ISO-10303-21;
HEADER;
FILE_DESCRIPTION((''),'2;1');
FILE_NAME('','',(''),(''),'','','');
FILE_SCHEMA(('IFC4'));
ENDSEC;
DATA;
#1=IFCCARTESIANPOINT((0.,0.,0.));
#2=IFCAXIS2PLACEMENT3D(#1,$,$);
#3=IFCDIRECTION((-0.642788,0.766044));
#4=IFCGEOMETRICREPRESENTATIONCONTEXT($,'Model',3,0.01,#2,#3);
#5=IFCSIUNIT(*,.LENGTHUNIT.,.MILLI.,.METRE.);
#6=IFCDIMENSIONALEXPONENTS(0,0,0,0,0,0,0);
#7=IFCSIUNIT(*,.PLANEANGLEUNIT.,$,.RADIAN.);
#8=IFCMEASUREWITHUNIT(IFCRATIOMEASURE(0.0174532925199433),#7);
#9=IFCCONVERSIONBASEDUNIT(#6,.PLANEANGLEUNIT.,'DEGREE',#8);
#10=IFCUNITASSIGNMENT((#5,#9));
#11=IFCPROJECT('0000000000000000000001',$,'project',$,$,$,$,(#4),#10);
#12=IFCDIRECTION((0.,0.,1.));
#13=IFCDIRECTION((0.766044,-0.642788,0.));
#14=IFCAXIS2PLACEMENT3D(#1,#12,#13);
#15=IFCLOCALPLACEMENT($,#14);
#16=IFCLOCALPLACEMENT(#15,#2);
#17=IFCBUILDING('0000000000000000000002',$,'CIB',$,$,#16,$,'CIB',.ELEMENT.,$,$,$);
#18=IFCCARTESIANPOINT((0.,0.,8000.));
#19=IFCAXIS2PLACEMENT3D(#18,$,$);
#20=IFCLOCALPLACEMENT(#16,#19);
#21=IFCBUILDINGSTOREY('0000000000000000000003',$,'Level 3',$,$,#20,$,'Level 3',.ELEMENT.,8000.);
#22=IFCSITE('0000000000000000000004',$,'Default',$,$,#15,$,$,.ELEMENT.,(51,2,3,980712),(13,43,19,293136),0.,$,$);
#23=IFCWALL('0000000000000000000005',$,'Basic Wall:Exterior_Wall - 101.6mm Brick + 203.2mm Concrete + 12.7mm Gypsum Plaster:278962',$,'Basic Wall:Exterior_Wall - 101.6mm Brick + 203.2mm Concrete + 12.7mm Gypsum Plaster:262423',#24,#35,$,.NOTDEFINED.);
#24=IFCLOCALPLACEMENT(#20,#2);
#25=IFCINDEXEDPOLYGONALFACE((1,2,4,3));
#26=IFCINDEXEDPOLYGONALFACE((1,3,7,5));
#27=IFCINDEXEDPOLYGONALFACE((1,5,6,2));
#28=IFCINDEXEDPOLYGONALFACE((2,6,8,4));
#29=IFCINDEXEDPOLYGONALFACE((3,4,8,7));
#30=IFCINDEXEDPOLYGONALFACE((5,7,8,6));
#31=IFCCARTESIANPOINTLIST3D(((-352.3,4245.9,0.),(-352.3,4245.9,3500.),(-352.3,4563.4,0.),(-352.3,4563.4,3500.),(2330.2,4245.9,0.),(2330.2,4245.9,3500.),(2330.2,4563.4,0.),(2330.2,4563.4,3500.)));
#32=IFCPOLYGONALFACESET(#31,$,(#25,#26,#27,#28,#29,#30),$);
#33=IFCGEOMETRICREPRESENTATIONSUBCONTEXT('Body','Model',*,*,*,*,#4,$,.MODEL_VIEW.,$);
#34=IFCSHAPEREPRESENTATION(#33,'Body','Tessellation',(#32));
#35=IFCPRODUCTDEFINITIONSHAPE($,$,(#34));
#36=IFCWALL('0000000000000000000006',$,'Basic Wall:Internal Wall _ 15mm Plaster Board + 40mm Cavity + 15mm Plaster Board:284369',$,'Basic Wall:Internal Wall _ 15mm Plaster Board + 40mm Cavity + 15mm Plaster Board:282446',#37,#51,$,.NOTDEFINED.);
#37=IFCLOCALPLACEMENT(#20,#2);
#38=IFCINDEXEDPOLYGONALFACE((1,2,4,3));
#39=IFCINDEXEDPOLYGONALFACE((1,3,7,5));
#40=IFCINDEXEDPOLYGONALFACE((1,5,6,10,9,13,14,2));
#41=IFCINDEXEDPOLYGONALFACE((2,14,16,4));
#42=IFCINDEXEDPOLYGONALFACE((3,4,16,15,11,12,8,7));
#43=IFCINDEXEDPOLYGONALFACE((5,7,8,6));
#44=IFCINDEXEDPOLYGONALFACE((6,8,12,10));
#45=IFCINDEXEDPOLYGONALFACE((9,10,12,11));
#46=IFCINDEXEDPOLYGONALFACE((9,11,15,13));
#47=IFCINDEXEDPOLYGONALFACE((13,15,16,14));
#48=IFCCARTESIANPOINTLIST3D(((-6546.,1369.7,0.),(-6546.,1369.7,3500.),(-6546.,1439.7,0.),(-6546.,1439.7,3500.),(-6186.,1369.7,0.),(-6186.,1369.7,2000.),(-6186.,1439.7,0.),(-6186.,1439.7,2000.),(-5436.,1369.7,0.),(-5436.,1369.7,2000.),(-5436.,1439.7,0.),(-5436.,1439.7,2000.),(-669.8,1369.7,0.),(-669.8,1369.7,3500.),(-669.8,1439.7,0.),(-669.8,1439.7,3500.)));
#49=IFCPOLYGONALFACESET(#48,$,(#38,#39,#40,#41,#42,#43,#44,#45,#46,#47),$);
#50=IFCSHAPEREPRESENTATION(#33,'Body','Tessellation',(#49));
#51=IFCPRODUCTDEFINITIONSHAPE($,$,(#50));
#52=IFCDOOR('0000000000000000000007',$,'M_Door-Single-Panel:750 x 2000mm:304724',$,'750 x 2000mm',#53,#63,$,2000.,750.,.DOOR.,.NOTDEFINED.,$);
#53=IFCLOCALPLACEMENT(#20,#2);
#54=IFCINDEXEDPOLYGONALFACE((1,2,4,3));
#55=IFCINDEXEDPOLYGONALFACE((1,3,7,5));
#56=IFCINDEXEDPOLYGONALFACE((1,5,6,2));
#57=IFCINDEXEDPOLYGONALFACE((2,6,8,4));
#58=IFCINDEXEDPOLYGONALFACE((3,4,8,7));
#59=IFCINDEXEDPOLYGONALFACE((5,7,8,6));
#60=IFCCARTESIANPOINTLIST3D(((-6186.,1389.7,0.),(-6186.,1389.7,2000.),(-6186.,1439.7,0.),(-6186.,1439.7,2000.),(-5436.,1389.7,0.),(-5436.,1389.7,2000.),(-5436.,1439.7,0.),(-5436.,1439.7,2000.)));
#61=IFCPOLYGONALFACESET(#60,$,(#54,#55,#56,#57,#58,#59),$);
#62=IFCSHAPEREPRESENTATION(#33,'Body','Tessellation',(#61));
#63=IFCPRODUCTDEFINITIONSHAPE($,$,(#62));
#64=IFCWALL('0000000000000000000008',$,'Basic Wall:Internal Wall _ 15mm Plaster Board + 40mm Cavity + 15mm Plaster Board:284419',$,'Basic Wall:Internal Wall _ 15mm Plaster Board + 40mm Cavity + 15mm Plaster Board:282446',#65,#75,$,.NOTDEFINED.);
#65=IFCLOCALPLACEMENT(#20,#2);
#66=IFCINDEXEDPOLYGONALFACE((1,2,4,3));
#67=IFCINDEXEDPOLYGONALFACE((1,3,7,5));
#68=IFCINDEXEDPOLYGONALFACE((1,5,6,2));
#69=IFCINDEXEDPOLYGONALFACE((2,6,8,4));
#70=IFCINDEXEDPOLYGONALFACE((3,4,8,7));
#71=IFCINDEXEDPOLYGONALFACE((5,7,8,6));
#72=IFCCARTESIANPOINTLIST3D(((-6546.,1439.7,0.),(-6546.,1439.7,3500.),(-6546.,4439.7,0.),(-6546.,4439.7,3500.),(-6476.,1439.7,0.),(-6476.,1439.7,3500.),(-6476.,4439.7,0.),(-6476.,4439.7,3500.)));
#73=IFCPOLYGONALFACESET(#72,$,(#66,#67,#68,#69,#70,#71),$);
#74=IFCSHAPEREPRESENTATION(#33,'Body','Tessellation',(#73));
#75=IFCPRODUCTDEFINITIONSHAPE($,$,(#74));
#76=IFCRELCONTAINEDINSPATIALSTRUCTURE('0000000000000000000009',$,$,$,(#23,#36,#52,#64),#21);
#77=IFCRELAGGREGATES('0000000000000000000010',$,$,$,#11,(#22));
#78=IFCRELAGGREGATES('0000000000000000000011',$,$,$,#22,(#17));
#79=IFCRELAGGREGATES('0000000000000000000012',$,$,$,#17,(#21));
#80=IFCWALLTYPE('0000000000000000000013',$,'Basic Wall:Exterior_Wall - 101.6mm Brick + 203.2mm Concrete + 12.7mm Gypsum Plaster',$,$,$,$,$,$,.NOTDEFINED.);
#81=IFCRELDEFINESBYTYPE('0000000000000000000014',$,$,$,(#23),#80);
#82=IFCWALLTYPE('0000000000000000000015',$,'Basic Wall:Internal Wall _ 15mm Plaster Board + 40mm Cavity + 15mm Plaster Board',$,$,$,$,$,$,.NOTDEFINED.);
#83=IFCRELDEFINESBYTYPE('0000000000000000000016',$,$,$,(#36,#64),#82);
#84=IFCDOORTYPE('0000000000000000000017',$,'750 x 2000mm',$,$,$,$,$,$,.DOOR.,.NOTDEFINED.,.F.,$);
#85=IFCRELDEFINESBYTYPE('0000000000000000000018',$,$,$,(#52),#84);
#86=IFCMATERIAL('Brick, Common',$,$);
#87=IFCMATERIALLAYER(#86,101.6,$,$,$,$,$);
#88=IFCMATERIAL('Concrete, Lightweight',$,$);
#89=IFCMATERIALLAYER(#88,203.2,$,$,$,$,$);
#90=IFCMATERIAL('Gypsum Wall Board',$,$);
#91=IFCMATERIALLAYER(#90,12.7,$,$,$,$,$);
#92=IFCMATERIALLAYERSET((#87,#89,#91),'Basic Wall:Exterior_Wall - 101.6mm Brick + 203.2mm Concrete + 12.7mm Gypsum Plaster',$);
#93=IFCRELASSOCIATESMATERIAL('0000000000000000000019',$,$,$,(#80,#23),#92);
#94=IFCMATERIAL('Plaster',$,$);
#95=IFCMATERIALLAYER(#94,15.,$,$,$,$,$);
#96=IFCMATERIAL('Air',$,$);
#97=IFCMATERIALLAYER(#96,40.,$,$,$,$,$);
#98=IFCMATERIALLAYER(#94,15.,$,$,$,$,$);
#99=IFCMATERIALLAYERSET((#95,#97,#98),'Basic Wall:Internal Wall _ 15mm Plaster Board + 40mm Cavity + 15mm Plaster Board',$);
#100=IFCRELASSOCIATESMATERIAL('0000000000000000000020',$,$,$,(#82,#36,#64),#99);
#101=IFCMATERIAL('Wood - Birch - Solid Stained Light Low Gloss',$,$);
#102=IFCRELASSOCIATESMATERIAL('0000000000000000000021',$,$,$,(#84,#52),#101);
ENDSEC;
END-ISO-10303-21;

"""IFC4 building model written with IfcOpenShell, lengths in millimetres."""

from ifc_helpers import new_model, entity, si_unit, converted_unit, direction, frame, frame_2d, origin, origin_2d_with_axis, place, context, subcontext, project, spatial, rectangle, extrude, source, transform, mapped, material, layer, layer_set, layer_usage, type_object, type_shapes, element, fill, save


model = new_model("IFC4")

# Units and contexts
model_context = context("Model", 3, precision=0.01, world=origin(), true_north=direction((-0.642788, 0.766044)))
body_context = subcontext(model_context, "Body", "Model", "MODEL_VIEW")
ifc_project = project(units=[si_unit("LENGTHUNIT", "METRE", prefix="MILLI"), converted_unit("PLANEANGLEUNIT", "DEGREE", entity("IfcRatioMeasure", 0.0174532925199433), si_unit("PLANEANGLEUNIT", "RADIAN"), dimensions=[0, 0, 0, 0, 0, 0, 0])], contexts=[model_context])

# Site, building, storey
site_placement = place(None, frame((0.0, 0.0, 0.0), z_axis=(0.0, 0.0, 1.0), x_axis=(0.766044, -0.642788, 0.0)))
site = spatial("IfcSite", under=ifc_project, at=site_placement, Name="Default", CompositionType="ELEMENT", RefLatitude=(51, 2, 3, 980712), RefLongitude=(13, 43, 19, 293136), RefElevation=0.0)
building_placement = place(site_placement, origin())
building = spatial("IfcBuilding", under=site, at=building_placement, Name="CIB", LongName="CIB", CompositionType="ELEMENT")
storey_placement = place(building_placement, frame((0.0, 0.0, 8000.0)))
storey = spatial("IfcBuildingStorey", under=building, at=storey_placement, Name="Level 3", LongName="Level 3", CompositionType="ELEMENT", Elevation=8000.0)

# Shared definitions
ifc_material_1 = material(Name="Plaster")

# Shared definitions
ifc_material_2 = material(Name="Brick, Common")
ifc_layer_1 = layer(ifc_material_2, 101.6)
ifc_material_3 = material(Name="Concrete, Lightweight")
ifc_layer_2 = layer(ifc_material_3, 203.2)
ifc_material_4 = material(Name="Gypsum Wall Board")
ifc_layer_3 = layer(ifc_material_4, 12.7)
ifc_layer_set_1 = layer_set([ifc_layer_1, ifc_layer_2, ifc_layer_3], Name="Basic Wall:Exterior_Wall - 101.6mm Brick + 203.2mm Concrete + 12.7mm Gypsum Plaster")
wall_type_1 = type_object("IfcWallType", Name="Basic Wall:Exterior_Wall - 101.6mm Brick + 203.2mm Concrete + 12.7mm Gypsum Plaster", PredefinedType="NOTDEFINED", material=ifc_layer_set_1)

# Wall
ifc_layer_usage_1 = layer_usage(ifc_layer_set_1, "AXIS2", "NEGATIVE", 158.8)
wall_1_placement = place(storey_placement, frame((-352.3, 4404.7, 0.0)))
element("IfcWall", 1, at=wall_1_placement, inside=storey, type_object=wall_type_1, material=ifc_layer_usage_1, Name="Basic Wall:Exterior_Wall - 101.6mm Brick + 203.2mm Concrete + 12.7mm Gypsum Plaster:278962", ObjectType="Basic Wall:Exterior_Wall - 101.6mm Brick + 203.2mm Concrete + 12.7mm Gypsum Plaster:262423", PredefinedType="NOTDEFINED", context=body_context, shape_type="SweptSolid", body=[
    extrude(rectangle(XDim=2682.5, YDim=317.5, at=frame_2d((1341.2, 0.0), x_axis=(-1.0, 0.0))), origin(), (0.0, 0.0, 1.0), 3500.0),
])

# Wall, opening, door
ifc_layer_4 = layer(ifc_material_1, 15.0)
ifc_material_5 = material(Name="Air")
ifc_layer_5 = layer(ifc_material_5, 40.0)
ifc_layer_6 = layer(ifc_material_1, 15.0)
ifc_layer_set_2 = layer_set([ifc_layer_4, ifc_layer_5, ifc_layer_6], Name="Basic Wall:Internal Wall _ 15mm Plaster Board + 40mm Cavity + 15mm Plaster Board")
ifc_layer_usage_2 = layer_usage(ifc_layer_set_2, "AXIS2", "NEGATIVE", 35.0)
wall_type_2 = type_object("IfcWallType", Name="Basic Wall:Internal Wall _ 15mm Plaster Board + 40mm Cavity + 15mm Plaster Board", PredefinedType="NOTDEFINED", material=ifc_layer_set_2)
wall_2_placement = place(storey_placement, frame((-669.8, 1404.7, 0.0), z_axis=(0.0, 0.0, 1.0), x_axis=(-1.0, 0.0, 0.0)))
wall_2 = element("IfcWall", 2, at=wall_2_placement, inside=storey, type_object=wall_type_2, material=ifc_layer_usage_2, Name="Basic Wall:Internal Wall _ 15mm Plaster Board + 40mm Cavity + 15mm Plaster Board:284369", ObjectType="Basic Wall:Internal Wall _ 15mm Plaster Board + 40mm Cavity + 15mm Plaster Board:282446", PredefinedType="NOTDEFINED", context=body_context, shape_type="SweptSolid", body=[
    extrude(rectangle(XDim=5876.2, YDim=70.0, at=frame_2d((2938.1, 0.0), x_axis=(-1.0, 0.0))), origin(), (0.0, 0.0, 1.0), 3500.0),
])
opening_1_placement = place(wall_2_placement, frame((5516.2, 35.0, 0.0)))
opening_1 = element("IfcOpeningElement", 3, at=opening_1_placement, cuts=wall_2, ObjectType="Opening", PredefinedType="OPENING", context=body_context, shape_type="SweptSolid", body=[
    extrude(rectangle(XDim=750.0, YDim=2000.0, at=frame_2d((1000.0, 375.0), x_axis=(0.0, -1.0))), frame((0.0, 0.0, 0.0), z_axis=(0.0, -1.0, 0.0), x_axis=(0.0, 0.0, 1.0)), (0.0, 0.0, 1.0), 70.0),
])
ifc_material_6 = material(Name="Wood - Birch - Solid Stained Light Low Gloss")
door_type = type_object("IfcDoorType", Name="750 x 2000mm", OperationType="NOTDEFINED", ParameterTakesPrecedence=False, PredefinedType="DOOR", material=ifc_material_6)
shared_shape_1 = source(origin(), body_context, "Body", "SweptSolid", [
    extrude(rectangle(XDim=750.0, YDim=50.0, at=origin_2d_with_axis()), frame((375.0, 45.0, 0.0)), (0.0, 0.0, 1.0), 2000.0),
])
type_shapes(door_type, [shared_shape_1])
door_placement = place(opening_1_placement, frame((0.0, 0.0, 0.0), z_axis=(0.0, 0.0, 1.0), x_axis=(-1.0, 0.0, 0.0)))
door = element("IfcDoor", 4, at=door_placement, inside=storey, type_object=door_type, material=ifc_material_6, Name="M_Door-Single-Panel:750 x 2000mm:304724", ObjectType="750 x 2000mm", OperationType="NOTDEFINED", OverallHeight=2000.0, OverallWidth=750.0, PredefinedType="DOOR", context=body_context, shape_type="MappedRepresentation", body=[
    mapped(shared_shape_1, transform((0.0, 0.0, 0.0), scale=1.0)),
])
fill(opening_1, door)

# Wall
ifc_layer_usage_3 = layer_usage(ifc_layer_set_2, "AXIS2", "NEGATIVE", 35.0)
wall_3_placement = place(storey_placement, frame((-6511.0, 1439.7, 0.0), z_axis=(0.0, 0.0, 1.0), x_axis=(0.0, 1.0, 0.0)))
element("IfcWall", 5, at=wall_3_placement, inside=storey, type_object=wall_type_2, material=ifc_layer_usage_3, Name="Basic Wall:Internal Wall _ 15mm Plaster Board + 40mm Cavity + 15mm Plaster Board:284419", ObjectType="Basic Wall:Internal Wall _ 15mm Plaster Board + 40mm Cavity + 15mm Plaster Board:282446", PredefinedType="NOTDEFINED", context=body_context, shape_type="SweptSolid", body=[
    extrude(rectangle(XDim=3000.0, YDim=70.0, at=frame_2d((1500.0, 0.0), x_axis=(-1.0, 0.0))), origin(), (0.0, 0.0, 1.0), 3500.0),
])

save(model, "model.ifc")
